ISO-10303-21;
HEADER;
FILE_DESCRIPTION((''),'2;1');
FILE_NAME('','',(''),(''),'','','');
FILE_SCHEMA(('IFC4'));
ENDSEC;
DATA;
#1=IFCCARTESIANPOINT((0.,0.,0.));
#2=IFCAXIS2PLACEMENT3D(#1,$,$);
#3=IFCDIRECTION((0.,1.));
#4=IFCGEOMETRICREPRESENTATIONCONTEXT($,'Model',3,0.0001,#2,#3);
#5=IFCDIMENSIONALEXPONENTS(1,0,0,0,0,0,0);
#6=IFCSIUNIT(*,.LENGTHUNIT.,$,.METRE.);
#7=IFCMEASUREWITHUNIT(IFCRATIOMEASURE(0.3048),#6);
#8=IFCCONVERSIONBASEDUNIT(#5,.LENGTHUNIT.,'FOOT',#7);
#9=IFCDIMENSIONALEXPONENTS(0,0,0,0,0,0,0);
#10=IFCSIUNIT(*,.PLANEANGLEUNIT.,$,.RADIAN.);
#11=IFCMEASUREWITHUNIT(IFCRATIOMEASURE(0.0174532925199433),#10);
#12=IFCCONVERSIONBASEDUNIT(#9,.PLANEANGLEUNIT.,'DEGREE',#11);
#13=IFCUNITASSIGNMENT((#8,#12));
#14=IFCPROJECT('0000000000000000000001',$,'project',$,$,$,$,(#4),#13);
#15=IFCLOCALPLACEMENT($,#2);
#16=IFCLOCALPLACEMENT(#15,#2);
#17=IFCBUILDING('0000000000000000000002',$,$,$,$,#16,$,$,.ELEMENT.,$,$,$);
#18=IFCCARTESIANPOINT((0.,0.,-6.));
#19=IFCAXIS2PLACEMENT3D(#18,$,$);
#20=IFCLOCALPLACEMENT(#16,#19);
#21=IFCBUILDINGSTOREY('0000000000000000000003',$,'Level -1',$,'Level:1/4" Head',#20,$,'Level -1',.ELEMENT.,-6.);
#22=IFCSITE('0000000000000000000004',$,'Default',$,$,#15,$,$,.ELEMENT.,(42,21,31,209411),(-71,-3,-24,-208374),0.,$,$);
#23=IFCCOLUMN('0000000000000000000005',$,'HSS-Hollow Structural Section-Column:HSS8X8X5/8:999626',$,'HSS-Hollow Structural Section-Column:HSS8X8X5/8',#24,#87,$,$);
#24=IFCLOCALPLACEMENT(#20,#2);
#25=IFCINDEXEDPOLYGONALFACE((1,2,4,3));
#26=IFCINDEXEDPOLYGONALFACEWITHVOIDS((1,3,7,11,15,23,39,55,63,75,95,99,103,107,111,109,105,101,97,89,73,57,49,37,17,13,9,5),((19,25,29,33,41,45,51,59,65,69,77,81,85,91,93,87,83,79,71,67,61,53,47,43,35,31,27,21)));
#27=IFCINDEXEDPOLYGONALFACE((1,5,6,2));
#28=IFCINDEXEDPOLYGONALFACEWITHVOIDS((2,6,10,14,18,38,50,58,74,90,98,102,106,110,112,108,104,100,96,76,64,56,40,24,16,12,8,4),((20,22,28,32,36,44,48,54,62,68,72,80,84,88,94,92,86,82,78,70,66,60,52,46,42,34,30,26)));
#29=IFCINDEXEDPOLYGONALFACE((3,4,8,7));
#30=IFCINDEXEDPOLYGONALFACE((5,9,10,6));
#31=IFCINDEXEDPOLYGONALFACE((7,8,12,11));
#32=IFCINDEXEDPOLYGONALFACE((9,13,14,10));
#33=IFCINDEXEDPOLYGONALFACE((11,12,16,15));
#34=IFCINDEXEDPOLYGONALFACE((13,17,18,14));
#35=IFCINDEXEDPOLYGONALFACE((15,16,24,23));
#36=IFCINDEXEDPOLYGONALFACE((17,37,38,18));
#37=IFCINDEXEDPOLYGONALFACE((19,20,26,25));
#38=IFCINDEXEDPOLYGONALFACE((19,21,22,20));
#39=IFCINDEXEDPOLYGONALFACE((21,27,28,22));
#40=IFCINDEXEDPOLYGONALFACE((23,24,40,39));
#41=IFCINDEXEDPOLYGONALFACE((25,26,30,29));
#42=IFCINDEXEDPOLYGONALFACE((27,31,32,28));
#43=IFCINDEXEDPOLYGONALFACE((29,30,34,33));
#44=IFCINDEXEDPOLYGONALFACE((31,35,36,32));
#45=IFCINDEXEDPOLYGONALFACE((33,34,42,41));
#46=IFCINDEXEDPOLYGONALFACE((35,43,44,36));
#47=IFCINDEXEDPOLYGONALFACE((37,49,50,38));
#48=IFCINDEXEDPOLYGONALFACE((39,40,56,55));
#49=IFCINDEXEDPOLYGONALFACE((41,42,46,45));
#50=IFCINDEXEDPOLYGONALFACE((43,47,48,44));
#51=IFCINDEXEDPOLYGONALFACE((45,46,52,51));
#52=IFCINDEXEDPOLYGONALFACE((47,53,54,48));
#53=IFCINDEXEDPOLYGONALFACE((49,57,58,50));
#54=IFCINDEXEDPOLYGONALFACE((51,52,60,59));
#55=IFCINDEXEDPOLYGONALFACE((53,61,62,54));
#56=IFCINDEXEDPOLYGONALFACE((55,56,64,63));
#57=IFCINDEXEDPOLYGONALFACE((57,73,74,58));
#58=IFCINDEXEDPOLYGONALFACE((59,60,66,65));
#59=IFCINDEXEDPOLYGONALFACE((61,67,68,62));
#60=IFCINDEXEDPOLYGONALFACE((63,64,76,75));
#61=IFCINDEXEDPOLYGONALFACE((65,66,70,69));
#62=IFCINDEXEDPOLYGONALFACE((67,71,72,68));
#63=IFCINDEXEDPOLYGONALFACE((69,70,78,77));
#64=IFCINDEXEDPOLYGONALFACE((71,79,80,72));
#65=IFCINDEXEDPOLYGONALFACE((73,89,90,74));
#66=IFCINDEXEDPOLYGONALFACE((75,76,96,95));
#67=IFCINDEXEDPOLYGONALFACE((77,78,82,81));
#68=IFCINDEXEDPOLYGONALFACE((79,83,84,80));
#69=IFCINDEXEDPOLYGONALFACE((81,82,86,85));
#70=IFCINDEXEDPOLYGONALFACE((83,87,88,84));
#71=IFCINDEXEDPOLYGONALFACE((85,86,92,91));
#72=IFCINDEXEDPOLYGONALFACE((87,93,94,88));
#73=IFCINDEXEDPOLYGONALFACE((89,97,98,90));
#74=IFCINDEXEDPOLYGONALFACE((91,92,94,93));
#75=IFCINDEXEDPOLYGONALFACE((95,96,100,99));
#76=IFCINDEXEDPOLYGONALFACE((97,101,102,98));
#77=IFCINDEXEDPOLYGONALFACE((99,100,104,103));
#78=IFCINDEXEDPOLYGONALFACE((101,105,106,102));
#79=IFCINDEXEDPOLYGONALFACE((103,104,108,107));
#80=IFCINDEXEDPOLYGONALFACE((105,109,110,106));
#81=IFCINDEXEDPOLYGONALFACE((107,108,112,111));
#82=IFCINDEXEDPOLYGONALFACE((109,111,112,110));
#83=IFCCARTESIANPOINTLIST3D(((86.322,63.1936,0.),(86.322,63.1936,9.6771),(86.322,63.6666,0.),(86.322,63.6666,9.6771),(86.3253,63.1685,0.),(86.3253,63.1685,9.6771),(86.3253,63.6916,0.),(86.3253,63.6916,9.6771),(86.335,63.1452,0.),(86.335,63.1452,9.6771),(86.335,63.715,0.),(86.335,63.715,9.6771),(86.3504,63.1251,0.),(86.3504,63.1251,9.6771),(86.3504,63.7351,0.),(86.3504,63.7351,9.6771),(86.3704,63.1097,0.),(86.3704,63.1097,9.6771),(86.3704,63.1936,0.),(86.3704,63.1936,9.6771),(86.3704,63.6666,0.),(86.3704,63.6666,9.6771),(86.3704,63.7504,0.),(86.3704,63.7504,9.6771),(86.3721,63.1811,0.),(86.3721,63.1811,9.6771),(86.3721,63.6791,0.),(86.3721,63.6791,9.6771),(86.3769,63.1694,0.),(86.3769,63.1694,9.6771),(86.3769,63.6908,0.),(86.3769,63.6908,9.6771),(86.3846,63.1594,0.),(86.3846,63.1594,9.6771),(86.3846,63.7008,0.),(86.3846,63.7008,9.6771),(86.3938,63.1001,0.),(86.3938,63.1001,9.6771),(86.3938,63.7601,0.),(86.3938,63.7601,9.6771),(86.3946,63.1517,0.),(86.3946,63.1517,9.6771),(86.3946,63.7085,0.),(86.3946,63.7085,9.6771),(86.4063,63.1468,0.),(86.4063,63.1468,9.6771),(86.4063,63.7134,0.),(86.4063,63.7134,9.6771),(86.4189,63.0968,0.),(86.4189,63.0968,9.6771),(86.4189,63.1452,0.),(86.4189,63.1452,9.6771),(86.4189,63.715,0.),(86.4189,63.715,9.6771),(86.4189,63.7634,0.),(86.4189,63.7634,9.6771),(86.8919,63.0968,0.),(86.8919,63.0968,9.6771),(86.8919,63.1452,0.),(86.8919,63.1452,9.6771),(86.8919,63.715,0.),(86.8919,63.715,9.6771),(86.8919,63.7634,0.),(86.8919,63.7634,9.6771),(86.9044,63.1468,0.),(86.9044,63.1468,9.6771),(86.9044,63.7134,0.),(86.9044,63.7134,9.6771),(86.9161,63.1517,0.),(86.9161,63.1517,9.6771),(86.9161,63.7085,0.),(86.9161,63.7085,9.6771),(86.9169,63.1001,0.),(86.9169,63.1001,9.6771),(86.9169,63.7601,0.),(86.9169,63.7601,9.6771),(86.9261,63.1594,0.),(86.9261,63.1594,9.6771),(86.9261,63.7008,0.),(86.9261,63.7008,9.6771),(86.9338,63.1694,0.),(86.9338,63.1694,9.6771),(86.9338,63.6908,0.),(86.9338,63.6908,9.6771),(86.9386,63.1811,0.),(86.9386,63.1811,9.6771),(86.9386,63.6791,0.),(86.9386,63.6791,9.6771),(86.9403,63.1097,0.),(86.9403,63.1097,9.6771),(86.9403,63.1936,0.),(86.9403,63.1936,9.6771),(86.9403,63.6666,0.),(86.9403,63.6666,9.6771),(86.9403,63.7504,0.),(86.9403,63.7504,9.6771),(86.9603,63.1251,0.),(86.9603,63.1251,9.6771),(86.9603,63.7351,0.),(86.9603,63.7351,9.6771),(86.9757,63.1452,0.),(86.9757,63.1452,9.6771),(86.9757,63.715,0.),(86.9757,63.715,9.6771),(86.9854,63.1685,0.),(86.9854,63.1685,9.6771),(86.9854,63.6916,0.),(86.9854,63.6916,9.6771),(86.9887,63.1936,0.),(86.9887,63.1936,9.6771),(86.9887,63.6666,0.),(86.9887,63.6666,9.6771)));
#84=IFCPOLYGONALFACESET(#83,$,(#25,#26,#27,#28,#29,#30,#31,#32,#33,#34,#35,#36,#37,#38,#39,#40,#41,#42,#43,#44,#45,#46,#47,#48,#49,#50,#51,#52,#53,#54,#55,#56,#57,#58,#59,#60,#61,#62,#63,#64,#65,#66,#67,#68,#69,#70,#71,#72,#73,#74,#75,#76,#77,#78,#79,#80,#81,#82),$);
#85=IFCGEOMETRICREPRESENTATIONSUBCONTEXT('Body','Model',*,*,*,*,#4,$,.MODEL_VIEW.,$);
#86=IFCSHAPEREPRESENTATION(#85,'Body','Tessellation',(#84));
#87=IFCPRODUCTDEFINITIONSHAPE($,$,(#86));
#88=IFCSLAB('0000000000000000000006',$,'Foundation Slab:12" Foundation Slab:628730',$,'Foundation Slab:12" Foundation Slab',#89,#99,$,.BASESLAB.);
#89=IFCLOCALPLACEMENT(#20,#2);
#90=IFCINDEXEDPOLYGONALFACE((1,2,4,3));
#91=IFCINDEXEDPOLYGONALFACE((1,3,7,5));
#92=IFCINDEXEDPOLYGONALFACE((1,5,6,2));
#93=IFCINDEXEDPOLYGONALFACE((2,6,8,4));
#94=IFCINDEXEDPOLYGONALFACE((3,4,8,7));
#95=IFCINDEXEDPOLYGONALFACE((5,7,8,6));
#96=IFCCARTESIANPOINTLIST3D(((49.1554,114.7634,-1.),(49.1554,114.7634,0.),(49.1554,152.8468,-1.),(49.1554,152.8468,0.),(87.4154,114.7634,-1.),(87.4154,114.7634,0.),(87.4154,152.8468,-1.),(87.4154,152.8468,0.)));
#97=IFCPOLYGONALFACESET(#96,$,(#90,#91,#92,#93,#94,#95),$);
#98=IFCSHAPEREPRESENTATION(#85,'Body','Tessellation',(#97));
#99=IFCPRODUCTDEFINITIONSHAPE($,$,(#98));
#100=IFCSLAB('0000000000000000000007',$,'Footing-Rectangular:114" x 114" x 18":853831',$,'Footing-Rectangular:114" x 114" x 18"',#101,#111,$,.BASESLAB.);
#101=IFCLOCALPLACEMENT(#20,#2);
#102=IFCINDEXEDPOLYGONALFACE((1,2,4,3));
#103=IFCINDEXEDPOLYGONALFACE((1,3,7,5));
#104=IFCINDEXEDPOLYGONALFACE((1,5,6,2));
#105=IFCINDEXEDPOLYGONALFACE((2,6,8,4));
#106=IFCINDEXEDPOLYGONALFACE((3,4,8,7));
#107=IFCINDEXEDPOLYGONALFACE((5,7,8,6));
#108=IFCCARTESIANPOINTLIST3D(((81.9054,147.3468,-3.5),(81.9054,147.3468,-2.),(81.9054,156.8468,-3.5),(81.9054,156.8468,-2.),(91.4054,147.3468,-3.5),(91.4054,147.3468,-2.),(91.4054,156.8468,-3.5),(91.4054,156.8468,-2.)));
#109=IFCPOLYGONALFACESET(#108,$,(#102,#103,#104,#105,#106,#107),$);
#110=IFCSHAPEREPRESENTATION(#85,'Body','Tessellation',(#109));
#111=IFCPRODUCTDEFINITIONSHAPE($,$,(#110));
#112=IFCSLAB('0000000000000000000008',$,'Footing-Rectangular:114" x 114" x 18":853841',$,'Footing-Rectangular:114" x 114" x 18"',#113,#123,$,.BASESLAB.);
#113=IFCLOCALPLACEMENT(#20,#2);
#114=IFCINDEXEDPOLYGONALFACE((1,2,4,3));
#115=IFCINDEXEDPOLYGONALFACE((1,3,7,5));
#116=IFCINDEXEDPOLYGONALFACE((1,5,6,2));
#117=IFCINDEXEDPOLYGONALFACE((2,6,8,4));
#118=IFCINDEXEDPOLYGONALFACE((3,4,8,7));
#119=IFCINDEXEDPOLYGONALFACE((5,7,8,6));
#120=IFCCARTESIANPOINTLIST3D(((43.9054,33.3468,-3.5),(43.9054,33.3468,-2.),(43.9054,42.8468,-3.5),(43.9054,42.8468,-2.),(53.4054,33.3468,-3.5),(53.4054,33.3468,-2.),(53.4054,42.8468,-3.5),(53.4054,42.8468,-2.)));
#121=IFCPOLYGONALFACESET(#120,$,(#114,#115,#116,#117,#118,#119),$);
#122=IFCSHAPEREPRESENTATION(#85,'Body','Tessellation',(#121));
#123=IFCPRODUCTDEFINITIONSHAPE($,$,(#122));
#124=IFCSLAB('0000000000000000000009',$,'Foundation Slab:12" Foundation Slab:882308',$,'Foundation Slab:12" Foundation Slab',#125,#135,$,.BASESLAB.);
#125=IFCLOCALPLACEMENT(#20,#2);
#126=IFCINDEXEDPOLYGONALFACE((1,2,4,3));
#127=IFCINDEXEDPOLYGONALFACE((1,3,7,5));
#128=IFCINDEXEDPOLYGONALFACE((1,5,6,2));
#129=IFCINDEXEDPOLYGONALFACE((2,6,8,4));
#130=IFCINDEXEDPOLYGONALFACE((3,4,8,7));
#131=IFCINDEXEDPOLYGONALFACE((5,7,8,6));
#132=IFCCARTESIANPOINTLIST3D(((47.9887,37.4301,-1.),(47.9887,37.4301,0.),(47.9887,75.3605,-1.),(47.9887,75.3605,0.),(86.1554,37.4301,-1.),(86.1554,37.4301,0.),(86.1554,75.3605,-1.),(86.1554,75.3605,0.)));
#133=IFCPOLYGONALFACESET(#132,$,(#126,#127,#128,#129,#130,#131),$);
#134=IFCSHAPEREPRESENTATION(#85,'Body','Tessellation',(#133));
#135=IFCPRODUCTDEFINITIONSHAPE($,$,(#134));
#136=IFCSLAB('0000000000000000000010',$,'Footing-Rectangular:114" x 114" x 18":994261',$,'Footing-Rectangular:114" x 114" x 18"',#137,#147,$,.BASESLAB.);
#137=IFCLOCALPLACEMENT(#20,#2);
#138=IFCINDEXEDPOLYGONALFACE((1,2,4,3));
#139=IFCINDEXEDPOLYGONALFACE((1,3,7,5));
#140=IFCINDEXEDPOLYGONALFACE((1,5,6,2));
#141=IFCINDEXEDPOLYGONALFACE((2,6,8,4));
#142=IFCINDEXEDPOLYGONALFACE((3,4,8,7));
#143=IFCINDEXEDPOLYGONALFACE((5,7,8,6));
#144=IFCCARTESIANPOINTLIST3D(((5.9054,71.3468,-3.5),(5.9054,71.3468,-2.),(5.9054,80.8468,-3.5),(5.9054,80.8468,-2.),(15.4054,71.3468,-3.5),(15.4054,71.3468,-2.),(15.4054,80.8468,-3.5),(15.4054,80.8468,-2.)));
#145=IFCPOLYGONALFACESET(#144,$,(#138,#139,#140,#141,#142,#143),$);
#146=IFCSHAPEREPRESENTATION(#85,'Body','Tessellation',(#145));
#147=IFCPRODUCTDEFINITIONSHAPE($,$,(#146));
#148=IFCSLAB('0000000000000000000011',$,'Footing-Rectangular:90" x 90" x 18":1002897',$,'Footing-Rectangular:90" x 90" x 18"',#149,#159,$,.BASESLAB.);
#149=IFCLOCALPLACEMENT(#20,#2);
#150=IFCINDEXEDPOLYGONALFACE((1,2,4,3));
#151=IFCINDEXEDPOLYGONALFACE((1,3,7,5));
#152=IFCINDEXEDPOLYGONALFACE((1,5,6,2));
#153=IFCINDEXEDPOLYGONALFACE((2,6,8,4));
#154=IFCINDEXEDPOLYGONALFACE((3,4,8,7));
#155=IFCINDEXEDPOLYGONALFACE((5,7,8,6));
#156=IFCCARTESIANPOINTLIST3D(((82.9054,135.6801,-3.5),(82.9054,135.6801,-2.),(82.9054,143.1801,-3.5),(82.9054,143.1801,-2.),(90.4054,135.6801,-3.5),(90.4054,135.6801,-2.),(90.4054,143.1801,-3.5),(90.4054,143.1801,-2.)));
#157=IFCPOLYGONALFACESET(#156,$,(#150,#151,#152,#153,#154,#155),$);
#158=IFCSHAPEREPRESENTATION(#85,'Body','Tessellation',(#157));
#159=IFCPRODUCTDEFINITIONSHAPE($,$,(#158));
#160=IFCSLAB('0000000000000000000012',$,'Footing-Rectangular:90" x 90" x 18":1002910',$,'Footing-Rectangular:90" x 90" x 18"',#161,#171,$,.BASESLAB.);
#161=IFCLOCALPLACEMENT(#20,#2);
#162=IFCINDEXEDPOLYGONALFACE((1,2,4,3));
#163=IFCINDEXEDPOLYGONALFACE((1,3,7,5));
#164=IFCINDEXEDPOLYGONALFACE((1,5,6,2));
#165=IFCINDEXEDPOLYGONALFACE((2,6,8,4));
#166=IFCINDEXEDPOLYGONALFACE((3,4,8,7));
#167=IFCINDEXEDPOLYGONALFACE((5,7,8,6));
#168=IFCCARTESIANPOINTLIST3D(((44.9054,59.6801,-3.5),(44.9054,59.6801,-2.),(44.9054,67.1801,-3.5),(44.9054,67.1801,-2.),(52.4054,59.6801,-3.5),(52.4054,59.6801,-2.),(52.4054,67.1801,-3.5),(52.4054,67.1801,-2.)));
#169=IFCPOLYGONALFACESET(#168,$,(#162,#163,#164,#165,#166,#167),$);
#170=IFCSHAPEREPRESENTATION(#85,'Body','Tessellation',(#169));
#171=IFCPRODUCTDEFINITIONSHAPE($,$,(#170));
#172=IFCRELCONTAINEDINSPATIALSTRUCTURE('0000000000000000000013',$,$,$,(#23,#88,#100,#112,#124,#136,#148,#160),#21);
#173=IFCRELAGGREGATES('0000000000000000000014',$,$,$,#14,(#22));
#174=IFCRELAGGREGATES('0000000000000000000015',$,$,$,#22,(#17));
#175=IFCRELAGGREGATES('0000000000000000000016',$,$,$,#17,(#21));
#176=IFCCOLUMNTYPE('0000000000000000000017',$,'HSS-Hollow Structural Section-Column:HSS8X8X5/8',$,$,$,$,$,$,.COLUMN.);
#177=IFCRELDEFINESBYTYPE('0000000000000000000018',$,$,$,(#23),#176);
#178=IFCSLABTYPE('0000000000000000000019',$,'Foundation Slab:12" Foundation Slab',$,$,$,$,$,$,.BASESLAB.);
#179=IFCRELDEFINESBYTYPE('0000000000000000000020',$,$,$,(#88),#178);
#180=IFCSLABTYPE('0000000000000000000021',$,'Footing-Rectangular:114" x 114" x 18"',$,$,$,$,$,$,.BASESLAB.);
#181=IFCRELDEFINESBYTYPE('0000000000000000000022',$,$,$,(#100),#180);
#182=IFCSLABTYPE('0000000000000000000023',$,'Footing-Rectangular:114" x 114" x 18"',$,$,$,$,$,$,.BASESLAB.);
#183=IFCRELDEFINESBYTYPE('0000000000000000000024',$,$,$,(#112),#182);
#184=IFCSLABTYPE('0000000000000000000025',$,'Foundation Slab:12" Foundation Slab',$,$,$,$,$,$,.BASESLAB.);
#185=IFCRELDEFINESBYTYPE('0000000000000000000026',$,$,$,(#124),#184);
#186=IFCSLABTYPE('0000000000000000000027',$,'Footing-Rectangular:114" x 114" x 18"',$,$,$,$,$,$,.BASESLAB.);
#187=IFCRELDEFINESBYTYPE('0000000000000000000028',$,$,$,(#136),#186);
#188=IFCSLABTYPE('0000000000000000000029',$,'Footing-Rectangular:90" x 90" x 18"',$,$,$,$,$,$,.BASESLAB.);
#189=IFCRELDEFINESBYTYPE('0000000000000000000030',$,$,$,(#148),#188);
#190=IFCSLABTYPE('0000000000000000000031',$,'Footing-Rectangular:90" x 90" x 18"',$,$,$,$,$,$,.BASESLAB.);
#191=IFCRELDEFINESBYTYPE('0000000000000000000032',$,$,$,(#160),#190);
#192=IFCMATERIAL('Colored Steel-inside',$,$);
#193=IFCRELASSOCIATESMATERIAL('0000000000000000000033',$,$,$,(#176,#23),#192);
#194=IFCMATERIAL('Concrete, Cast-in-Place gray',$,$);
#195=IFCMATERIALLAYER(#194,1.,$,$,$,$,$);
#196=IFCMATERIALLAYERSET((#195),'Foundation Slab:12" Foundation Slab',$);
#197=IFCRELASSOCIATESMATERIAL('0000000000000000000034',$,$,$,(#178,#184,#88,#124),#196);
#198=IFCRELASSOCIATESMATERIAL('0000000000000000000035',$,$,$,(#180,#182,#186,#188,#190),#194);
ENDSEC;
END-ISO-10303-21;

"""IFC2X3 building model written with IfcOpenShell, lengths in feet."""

from ifc_helpers import new_model, entity, si_unit, converted_unit, direction, frame, frame_2d, origin, origin_2d_with_axis, place, context, subcontext, project, spatial, polyline, circle_curve, parameter, trimmed, segment, composite_curve, rectangle, outline, extrude, source, transform, mapped, material, layer, layer_set, layer_usage, type_object, type_shapes, element, save


model = new_model("IFC2X3")

# Units and contexts
model_context = context("Model", 3, precision=0.0001, world=origin(), true_north=direction((0.0, 1.0)))
body_context = subcontext(model_context, "Body", "Model", "MODEL_VIEW")
ifc_project = project(units=[converted_unit("LENGTHUNIT", "FOOT", entity("IfcRatioMeasure", 0.3048), si_unit("LENGTHUNIT", "METRE"), dimensions=[1, 0, 0, 0, 0, 0, 0]), converted_unit("PLANEANGLEUNIT", "DEGREE", entity("IfcRatioMeasure", 0.0174532925199433), si_unit("PLANEANGLEUNIT", "RADIAN"), dimensions=[0, 0, 0, 0, 0, 0, 0])], contexts=[model_context])

# Site, building, storey
site_placement = place(None, origin())
site = spatial("IfcSite", under=ifc_project, at=site_placement, Name="Default", CompositionType="ELEMENT", RefLatitude=(42, 21, 31, 209411), RefLongitude=(-71, -3, -24, -208374), RefElevation=0.0)
building_placement = place(site_placement, origin())
building = spatial("IfcBuilding", under=site, at=building_placement, CompositionType="ELEMENT")
storey_placement = place(building_placement, frame((0.0, 0.0, -6.0)))
storey = spatial("IfcBuildingStorey", under=building, at=storey_placement, Name="Level -1", ObjectType="Level:1/4\" Head", LongName="Level -1", CompositionType="ELEMENT", Elevation=-6.0)

# Column
ifc_material_1 = material(Name="Colored Steel-inside")
ifc_material_2 = material(Name="Concrete, Cast-in-Place gray")
column_type_1 = type_object("IfcColumnType", Name="HSS-Hollow Structural Section-Column:HSS8X8X5/8", PredefinedType="COLUMN", material=ifc_material_1)
shared_shape_1 = source(origin(), body_context, "Body", "SweptSolid", [
    extrude(outline(composite_curve([segment(polyline([(-0.2365, -0.3333), (0.2365, -0.3333)]), True, "CONTINUOUS"), segment(trimmed(circle_curve(frame_2d((0.2365, -0.2365), x_axis=(-1.0, 0.0)), 0.0968), [parameter(90.0)], [parameter(180.0)], True, "PARAMETER"), True, "CONTINUOUS"), segment(polyline([(0.3333, -0.2365), (0.3333, 0.2365)]), True, "CONTINUOUS"), segment(trimmed(circle_curve(frame_2d((0.2365, 0.2365), x_axis=(-1.0, 0.0)), 0.0968), [parameter(180.0)], [parameter(270.0)], True, "PARAMETER"), True, "CONTINUOUS"), segment(polyline([(0.2365, 0.3333), (-0.2365, 0.3333)]), True, "CONTINUOUS"), segment(trimmed(circle_curve(frame_2d((-0.2365, 0.2365), x_axis=(-1.0, 0.0)), 0.0968), [parameter(270.0)], [parameter(360.0)], True, "PARAMETER"), True, "CONTINUOUS"), segment(polyline([(-0.3333, 0.2365), (-0.3333, -0.2365)]), True, "CONTINUOUS"), segment(trimmed(circle_curve(frame_2d((-0.2365, -0.2365), x_axis=(-1.0, 0.0)), 0.0968), [parameter(360.0)], [parameter(90.0)], True, "PARAMETER"), True, "CONTINUOUS")], self_intersect=False), holes=[composite_curve([segment(trimmed(circle_curve(frame_2d((-0.2365, -0.2365), x_axis=(-1.0, 0.0)), 0.0484), [parameter(0.0)], [parameter(90.0)], True, "PARAMETER"), False, "CONTINUOUS"), segment(polyline([(-0.2849, -0.2365), (-0.2849, 0.2365)]), True, "CONTINUOUS"), segment(trimmed(circle_curve(frame_2d((-0.2365, 0.2365), x_axis=(-1.0, 0.0)), 0.0484), [parameter(270.0)], [parameter(360.0)], True, "PARAMETER"), False, "CONTINUOUS"), segment(polyline([(-0.2365, 0.2849), (0.2365, 0.2849)]), True, "CONTINUOUS"), segment(trimmed(circle_curve(frame_2d((0.2365, 0.2365), x_axis=(-1.0, 0.0)), 0.0484), [parameter(180.0)], [parameter(270.0)], True, "PARAMETER"), False, "CONTINUOUS"), segment(polyline([(0.2849, 0.2365), (0.2849, -0.2365)]), True, "CONTINUOUS"), segment(trimmed(circle_curve(frame_2d((0.2365, -0.2365), x_axis=(-1.0, 0.0)), 0.0484), [parameter(90.0)], [parameter(180.0)], True, "PARAMETER"), False, "CONTINUOUS"), segment(polyline([(0.2365, -0.2849), (-0.2365, -0.2849)]), True, "CONTINUOUS")], self_intersect=False)]), frame((0.0, 0.0, -6.0), z_axis=(0.0, 0.0, 1.0), x_axis=(-1.0, 0.0, 0.0)), (0.0, 0.0, 1.0), 9.6771),
])
type_shapes(column_type_1, [shared_shape_1])
for number, where, z_axis, x_axis, name in (
    (1, (86.6554, 63.4301, 6.0), (0.0, 0.0, 1.0), (-1.0, 0.0, 0.0), "HSS-Hollow Structural Section-Column:HSS8X8X5/8:999626"),
):
    element("IfcColumn", number, at=place(storey_placement, frame(where, z_axis=z_axis, x_axis=x_axis)), inside=storey, type_object=column_type_1, material=ifc_material_1, Name=name, ObjectType="HSS-Hollow Structural Section-Column:HSS8X8X5/8", context=body_context, shape_type="MappedRepresentation", body=[
        mapped(shared_shape_1, transform((0.0, 0.0, 0.0), scale=1.0)),
    ])

# Slabs
ifc_layer_1 = layer(ifc_material_2, 1.0)
ifc_layer_set_1 = layer_set([ifc_layer_1], Name="Foundation Slab:12\" Foundation Slab")
ifc_layer_usage_1 = layer_usage(ifc_layer_set_1, "AXIS3", "POSITIVE", 0.0)
slab_type_1 = type_object("IfcSlabType", Name="Foundation Slab:12\" Foundation Slab", PredefinedType="BASESLAB", material=ifc_layer_set_1)
slab_1_placement = place(storey_placement, origin())
element("IfcSlab", 2, at=slab_1_placement, inside=storey, type_object=slab_type_1, material=ifc_layer_usage_1, Name="Foundation Slab:12\" Foundation Slab:628730", ObjectType="Foundation Slab:12\" Foundation Slab", PredefinedType="BASESLAB", context=body_context, shape_type="SweptSolid", body=[
    extrude(rectangle(XDim=38.0833, YDim=38.26, at=frame_2d((0.0, 0.0), x_axis=(1.0, 0.0))), frame((68.2854, 133.8051, 0.0), z_axis=(0.0, 0.0, -1.0), x_axis=(0.0, 1.0, 0.0)), (0.0, 0.0, 1.0), 1.0),
])
slab_type_2 = type_object("IfcSlabType", Name="Footing-Rectangular:114\" x 114\" x 18\"", PredefinedType="BASESLAB", material=ifc_material_2)
slab_2_placement = place(storey_placement, origin())
element("IfcSlab", 3, at=slab_2_placement, inside=storey, type_object=slab_type_2, Name="Footing-Rectangular:114\" x 114\" x 18\":853831", ObjectType="Footing-Rectangular:114\" x 114\" x 18\"", PredefinedType="BASESLAB", context=body_context, shape_type="SweptSolid", body=[
    extrude(rectangle(XDim=9.5, YDim=9.5, at=origin_2d_with_axis()), frame((86.6554, 152.0968, -3.5), z_axis=(0.0, 0.0, 1.0), x_axis=(-1.0, 0.0, 0.0)), (0.0, 0.0, 1.0), 1.5),
])
slab_type_3 = type_object("IfcSlabType", Name="Footing-Rectangular:114\" x 114\" x 18\"", PredefinedType="BASESLAB", material=ifc_material_2)
slab_3_placement = place(storey_placement, origin())
element("IfcSlab", 4, at=slab_3_placement, inside=storey, type_object=slab_type_3, Name="Footing-Rectangular:114\" x 114\" x 18\":853841", ObjectType="Footing-Rectangular:114\" x 114\" x 18\"", PredefinedType="BASESLAB", context=body_context, shape_type="SweptSolid", body=[
    extrude(rectangle(XDim=9.5, YDim=9.5, at=origin_2d_with_axis()), frame((48.6554, 38.0968, -3.5), z_axis=(0.0, 0.0, 1.0), x_axis=(-1.0, 0.0, 0.0)), (0.0, 0.0, 1.0), 1.5),
])
ifc_layer_usage_2 = layer_usage(ifc_layer_set_1, "AXIS3", "POSITIVE", 0.0)
slab_type_4 = type_object("IfcSlabType", Name="Foundation Slab:12\" Foundation Slab", PredefinedType="BASESLAB", material=ifc_layer_set_1)
slab_4_placement = place(storey_placement, origin())
element("IfcSlab", 5, at=slab_4_placement, inside=storey, type_object=slab_type_4, material=ifc_layer_usage_2, Name="Foundation Slab:12\" Foundation Slab:882308", ObjectType="Foundation Slab:12\" Foundation Slab", PredefinedType="BASESLAB", context=body_context, shape_type="SweptSolid", body=[
    extrude(rectangle(XDim=37.9304, YDim=38.1667, at=frame_2d((0.0, 0.0), x_axis=(1.0, 0.0))), frame((67.072, 56.3953, 0.0), z_axis=(0.0, 0.0, -1.0), x_axis=(0.0, 1.0, 0.0)), (0.0, 0.0, 1.0), 1.0),
])
slab_type_5 = type_object("IfcSlabType", Name="Footing-Rectangular:114\" x 114\" x 18\"", PredefinedType="BASESLAB", material=ifc_material_2)
slab_5_placement = place(storey_placement, origin())
element("IfcSlab", 6, at=slab_5_placement, inside=storey, type_object=slab_type_5, Name="Footing-Rectangular:114\" x 114\" x 18\":994261", ObjectType="Footing-Rectangular:114\" x 114\" x 18\"", PredefinedType="BASESLAB", context=body_context, shape_type="SweptSolid", body=[
    extrude(rectangle(XDim=9.5, YDim=9.5, at=origin_2d_with_axis()), frame((10.6554, 76.0968, -3.5), z_axis=(0.0, 0.0, 1.0), x_axis=(-1.0, 0.0, 0.0)), (0.0, 0.0, 1.0), 1.5),
])
slab_type_6 = type_object("IfcSlabType", Name="Footing-Rectangular:90\" x 90\" x 18\"", PredefinedType="BASESLAB", material=ifc_material_2)
slab_6_placement = place(storey_placement, origin())
element("IfcSlab", 7, at=slab_6_placement, inside=storey, type_object=slab_type_6, Name="Footing-Rectangular:90\" x 90\" x 18\":1002897", ObjectType="Footing-Rectangular:90\" x 90\" x 18\"", PredefinedType="BASESLAB", context=body_context, shape_type="SweptSolid", body=[
    extrude(rectangle(XDim=7.5, YDim=7.5, at=origin_2d_with_axis()), frame((86.6554, 139.4301, -3.5), z_axis=(0.0, 0.0, 1.0), x_axis=(-1.0, 0.0, 0.0)), (0.0, 0.0, 1.0), 1.5),
])
slab_type_7 = type_object("IfcSlabType", Name="Footing-Rectangular:90\" x 90\" x 18\"", PredefinedType="BASESLAB", material=ifc_material_2)
slab_7_placement = place(storey_placement, origin())
element("IfcSlab", 8, at=slab_7_placement, inside=storey, type_object=slab_type_7, Name="Footing-Rectangular:90\" x 90\" x 18\":1002910", ObjectType="Footing-Rectangular:90\" x 90\" x 18\"", PredefinedType="BASESLAB", context=body_context, shape_type="SweptSolid", body=[
    extrude(rectangle(XDim=7.5, YDim=7.5, at=origin_2d_with_axis()), frame((48.6554, 63.4301, -3.5), z_axis=(0.0, 0.0, 1.0), x_axis=(-1.0, 0.0, 0.0)), (0.0, 0.0, 1.0), 1.5),
])

save(model, "model.ifc")
